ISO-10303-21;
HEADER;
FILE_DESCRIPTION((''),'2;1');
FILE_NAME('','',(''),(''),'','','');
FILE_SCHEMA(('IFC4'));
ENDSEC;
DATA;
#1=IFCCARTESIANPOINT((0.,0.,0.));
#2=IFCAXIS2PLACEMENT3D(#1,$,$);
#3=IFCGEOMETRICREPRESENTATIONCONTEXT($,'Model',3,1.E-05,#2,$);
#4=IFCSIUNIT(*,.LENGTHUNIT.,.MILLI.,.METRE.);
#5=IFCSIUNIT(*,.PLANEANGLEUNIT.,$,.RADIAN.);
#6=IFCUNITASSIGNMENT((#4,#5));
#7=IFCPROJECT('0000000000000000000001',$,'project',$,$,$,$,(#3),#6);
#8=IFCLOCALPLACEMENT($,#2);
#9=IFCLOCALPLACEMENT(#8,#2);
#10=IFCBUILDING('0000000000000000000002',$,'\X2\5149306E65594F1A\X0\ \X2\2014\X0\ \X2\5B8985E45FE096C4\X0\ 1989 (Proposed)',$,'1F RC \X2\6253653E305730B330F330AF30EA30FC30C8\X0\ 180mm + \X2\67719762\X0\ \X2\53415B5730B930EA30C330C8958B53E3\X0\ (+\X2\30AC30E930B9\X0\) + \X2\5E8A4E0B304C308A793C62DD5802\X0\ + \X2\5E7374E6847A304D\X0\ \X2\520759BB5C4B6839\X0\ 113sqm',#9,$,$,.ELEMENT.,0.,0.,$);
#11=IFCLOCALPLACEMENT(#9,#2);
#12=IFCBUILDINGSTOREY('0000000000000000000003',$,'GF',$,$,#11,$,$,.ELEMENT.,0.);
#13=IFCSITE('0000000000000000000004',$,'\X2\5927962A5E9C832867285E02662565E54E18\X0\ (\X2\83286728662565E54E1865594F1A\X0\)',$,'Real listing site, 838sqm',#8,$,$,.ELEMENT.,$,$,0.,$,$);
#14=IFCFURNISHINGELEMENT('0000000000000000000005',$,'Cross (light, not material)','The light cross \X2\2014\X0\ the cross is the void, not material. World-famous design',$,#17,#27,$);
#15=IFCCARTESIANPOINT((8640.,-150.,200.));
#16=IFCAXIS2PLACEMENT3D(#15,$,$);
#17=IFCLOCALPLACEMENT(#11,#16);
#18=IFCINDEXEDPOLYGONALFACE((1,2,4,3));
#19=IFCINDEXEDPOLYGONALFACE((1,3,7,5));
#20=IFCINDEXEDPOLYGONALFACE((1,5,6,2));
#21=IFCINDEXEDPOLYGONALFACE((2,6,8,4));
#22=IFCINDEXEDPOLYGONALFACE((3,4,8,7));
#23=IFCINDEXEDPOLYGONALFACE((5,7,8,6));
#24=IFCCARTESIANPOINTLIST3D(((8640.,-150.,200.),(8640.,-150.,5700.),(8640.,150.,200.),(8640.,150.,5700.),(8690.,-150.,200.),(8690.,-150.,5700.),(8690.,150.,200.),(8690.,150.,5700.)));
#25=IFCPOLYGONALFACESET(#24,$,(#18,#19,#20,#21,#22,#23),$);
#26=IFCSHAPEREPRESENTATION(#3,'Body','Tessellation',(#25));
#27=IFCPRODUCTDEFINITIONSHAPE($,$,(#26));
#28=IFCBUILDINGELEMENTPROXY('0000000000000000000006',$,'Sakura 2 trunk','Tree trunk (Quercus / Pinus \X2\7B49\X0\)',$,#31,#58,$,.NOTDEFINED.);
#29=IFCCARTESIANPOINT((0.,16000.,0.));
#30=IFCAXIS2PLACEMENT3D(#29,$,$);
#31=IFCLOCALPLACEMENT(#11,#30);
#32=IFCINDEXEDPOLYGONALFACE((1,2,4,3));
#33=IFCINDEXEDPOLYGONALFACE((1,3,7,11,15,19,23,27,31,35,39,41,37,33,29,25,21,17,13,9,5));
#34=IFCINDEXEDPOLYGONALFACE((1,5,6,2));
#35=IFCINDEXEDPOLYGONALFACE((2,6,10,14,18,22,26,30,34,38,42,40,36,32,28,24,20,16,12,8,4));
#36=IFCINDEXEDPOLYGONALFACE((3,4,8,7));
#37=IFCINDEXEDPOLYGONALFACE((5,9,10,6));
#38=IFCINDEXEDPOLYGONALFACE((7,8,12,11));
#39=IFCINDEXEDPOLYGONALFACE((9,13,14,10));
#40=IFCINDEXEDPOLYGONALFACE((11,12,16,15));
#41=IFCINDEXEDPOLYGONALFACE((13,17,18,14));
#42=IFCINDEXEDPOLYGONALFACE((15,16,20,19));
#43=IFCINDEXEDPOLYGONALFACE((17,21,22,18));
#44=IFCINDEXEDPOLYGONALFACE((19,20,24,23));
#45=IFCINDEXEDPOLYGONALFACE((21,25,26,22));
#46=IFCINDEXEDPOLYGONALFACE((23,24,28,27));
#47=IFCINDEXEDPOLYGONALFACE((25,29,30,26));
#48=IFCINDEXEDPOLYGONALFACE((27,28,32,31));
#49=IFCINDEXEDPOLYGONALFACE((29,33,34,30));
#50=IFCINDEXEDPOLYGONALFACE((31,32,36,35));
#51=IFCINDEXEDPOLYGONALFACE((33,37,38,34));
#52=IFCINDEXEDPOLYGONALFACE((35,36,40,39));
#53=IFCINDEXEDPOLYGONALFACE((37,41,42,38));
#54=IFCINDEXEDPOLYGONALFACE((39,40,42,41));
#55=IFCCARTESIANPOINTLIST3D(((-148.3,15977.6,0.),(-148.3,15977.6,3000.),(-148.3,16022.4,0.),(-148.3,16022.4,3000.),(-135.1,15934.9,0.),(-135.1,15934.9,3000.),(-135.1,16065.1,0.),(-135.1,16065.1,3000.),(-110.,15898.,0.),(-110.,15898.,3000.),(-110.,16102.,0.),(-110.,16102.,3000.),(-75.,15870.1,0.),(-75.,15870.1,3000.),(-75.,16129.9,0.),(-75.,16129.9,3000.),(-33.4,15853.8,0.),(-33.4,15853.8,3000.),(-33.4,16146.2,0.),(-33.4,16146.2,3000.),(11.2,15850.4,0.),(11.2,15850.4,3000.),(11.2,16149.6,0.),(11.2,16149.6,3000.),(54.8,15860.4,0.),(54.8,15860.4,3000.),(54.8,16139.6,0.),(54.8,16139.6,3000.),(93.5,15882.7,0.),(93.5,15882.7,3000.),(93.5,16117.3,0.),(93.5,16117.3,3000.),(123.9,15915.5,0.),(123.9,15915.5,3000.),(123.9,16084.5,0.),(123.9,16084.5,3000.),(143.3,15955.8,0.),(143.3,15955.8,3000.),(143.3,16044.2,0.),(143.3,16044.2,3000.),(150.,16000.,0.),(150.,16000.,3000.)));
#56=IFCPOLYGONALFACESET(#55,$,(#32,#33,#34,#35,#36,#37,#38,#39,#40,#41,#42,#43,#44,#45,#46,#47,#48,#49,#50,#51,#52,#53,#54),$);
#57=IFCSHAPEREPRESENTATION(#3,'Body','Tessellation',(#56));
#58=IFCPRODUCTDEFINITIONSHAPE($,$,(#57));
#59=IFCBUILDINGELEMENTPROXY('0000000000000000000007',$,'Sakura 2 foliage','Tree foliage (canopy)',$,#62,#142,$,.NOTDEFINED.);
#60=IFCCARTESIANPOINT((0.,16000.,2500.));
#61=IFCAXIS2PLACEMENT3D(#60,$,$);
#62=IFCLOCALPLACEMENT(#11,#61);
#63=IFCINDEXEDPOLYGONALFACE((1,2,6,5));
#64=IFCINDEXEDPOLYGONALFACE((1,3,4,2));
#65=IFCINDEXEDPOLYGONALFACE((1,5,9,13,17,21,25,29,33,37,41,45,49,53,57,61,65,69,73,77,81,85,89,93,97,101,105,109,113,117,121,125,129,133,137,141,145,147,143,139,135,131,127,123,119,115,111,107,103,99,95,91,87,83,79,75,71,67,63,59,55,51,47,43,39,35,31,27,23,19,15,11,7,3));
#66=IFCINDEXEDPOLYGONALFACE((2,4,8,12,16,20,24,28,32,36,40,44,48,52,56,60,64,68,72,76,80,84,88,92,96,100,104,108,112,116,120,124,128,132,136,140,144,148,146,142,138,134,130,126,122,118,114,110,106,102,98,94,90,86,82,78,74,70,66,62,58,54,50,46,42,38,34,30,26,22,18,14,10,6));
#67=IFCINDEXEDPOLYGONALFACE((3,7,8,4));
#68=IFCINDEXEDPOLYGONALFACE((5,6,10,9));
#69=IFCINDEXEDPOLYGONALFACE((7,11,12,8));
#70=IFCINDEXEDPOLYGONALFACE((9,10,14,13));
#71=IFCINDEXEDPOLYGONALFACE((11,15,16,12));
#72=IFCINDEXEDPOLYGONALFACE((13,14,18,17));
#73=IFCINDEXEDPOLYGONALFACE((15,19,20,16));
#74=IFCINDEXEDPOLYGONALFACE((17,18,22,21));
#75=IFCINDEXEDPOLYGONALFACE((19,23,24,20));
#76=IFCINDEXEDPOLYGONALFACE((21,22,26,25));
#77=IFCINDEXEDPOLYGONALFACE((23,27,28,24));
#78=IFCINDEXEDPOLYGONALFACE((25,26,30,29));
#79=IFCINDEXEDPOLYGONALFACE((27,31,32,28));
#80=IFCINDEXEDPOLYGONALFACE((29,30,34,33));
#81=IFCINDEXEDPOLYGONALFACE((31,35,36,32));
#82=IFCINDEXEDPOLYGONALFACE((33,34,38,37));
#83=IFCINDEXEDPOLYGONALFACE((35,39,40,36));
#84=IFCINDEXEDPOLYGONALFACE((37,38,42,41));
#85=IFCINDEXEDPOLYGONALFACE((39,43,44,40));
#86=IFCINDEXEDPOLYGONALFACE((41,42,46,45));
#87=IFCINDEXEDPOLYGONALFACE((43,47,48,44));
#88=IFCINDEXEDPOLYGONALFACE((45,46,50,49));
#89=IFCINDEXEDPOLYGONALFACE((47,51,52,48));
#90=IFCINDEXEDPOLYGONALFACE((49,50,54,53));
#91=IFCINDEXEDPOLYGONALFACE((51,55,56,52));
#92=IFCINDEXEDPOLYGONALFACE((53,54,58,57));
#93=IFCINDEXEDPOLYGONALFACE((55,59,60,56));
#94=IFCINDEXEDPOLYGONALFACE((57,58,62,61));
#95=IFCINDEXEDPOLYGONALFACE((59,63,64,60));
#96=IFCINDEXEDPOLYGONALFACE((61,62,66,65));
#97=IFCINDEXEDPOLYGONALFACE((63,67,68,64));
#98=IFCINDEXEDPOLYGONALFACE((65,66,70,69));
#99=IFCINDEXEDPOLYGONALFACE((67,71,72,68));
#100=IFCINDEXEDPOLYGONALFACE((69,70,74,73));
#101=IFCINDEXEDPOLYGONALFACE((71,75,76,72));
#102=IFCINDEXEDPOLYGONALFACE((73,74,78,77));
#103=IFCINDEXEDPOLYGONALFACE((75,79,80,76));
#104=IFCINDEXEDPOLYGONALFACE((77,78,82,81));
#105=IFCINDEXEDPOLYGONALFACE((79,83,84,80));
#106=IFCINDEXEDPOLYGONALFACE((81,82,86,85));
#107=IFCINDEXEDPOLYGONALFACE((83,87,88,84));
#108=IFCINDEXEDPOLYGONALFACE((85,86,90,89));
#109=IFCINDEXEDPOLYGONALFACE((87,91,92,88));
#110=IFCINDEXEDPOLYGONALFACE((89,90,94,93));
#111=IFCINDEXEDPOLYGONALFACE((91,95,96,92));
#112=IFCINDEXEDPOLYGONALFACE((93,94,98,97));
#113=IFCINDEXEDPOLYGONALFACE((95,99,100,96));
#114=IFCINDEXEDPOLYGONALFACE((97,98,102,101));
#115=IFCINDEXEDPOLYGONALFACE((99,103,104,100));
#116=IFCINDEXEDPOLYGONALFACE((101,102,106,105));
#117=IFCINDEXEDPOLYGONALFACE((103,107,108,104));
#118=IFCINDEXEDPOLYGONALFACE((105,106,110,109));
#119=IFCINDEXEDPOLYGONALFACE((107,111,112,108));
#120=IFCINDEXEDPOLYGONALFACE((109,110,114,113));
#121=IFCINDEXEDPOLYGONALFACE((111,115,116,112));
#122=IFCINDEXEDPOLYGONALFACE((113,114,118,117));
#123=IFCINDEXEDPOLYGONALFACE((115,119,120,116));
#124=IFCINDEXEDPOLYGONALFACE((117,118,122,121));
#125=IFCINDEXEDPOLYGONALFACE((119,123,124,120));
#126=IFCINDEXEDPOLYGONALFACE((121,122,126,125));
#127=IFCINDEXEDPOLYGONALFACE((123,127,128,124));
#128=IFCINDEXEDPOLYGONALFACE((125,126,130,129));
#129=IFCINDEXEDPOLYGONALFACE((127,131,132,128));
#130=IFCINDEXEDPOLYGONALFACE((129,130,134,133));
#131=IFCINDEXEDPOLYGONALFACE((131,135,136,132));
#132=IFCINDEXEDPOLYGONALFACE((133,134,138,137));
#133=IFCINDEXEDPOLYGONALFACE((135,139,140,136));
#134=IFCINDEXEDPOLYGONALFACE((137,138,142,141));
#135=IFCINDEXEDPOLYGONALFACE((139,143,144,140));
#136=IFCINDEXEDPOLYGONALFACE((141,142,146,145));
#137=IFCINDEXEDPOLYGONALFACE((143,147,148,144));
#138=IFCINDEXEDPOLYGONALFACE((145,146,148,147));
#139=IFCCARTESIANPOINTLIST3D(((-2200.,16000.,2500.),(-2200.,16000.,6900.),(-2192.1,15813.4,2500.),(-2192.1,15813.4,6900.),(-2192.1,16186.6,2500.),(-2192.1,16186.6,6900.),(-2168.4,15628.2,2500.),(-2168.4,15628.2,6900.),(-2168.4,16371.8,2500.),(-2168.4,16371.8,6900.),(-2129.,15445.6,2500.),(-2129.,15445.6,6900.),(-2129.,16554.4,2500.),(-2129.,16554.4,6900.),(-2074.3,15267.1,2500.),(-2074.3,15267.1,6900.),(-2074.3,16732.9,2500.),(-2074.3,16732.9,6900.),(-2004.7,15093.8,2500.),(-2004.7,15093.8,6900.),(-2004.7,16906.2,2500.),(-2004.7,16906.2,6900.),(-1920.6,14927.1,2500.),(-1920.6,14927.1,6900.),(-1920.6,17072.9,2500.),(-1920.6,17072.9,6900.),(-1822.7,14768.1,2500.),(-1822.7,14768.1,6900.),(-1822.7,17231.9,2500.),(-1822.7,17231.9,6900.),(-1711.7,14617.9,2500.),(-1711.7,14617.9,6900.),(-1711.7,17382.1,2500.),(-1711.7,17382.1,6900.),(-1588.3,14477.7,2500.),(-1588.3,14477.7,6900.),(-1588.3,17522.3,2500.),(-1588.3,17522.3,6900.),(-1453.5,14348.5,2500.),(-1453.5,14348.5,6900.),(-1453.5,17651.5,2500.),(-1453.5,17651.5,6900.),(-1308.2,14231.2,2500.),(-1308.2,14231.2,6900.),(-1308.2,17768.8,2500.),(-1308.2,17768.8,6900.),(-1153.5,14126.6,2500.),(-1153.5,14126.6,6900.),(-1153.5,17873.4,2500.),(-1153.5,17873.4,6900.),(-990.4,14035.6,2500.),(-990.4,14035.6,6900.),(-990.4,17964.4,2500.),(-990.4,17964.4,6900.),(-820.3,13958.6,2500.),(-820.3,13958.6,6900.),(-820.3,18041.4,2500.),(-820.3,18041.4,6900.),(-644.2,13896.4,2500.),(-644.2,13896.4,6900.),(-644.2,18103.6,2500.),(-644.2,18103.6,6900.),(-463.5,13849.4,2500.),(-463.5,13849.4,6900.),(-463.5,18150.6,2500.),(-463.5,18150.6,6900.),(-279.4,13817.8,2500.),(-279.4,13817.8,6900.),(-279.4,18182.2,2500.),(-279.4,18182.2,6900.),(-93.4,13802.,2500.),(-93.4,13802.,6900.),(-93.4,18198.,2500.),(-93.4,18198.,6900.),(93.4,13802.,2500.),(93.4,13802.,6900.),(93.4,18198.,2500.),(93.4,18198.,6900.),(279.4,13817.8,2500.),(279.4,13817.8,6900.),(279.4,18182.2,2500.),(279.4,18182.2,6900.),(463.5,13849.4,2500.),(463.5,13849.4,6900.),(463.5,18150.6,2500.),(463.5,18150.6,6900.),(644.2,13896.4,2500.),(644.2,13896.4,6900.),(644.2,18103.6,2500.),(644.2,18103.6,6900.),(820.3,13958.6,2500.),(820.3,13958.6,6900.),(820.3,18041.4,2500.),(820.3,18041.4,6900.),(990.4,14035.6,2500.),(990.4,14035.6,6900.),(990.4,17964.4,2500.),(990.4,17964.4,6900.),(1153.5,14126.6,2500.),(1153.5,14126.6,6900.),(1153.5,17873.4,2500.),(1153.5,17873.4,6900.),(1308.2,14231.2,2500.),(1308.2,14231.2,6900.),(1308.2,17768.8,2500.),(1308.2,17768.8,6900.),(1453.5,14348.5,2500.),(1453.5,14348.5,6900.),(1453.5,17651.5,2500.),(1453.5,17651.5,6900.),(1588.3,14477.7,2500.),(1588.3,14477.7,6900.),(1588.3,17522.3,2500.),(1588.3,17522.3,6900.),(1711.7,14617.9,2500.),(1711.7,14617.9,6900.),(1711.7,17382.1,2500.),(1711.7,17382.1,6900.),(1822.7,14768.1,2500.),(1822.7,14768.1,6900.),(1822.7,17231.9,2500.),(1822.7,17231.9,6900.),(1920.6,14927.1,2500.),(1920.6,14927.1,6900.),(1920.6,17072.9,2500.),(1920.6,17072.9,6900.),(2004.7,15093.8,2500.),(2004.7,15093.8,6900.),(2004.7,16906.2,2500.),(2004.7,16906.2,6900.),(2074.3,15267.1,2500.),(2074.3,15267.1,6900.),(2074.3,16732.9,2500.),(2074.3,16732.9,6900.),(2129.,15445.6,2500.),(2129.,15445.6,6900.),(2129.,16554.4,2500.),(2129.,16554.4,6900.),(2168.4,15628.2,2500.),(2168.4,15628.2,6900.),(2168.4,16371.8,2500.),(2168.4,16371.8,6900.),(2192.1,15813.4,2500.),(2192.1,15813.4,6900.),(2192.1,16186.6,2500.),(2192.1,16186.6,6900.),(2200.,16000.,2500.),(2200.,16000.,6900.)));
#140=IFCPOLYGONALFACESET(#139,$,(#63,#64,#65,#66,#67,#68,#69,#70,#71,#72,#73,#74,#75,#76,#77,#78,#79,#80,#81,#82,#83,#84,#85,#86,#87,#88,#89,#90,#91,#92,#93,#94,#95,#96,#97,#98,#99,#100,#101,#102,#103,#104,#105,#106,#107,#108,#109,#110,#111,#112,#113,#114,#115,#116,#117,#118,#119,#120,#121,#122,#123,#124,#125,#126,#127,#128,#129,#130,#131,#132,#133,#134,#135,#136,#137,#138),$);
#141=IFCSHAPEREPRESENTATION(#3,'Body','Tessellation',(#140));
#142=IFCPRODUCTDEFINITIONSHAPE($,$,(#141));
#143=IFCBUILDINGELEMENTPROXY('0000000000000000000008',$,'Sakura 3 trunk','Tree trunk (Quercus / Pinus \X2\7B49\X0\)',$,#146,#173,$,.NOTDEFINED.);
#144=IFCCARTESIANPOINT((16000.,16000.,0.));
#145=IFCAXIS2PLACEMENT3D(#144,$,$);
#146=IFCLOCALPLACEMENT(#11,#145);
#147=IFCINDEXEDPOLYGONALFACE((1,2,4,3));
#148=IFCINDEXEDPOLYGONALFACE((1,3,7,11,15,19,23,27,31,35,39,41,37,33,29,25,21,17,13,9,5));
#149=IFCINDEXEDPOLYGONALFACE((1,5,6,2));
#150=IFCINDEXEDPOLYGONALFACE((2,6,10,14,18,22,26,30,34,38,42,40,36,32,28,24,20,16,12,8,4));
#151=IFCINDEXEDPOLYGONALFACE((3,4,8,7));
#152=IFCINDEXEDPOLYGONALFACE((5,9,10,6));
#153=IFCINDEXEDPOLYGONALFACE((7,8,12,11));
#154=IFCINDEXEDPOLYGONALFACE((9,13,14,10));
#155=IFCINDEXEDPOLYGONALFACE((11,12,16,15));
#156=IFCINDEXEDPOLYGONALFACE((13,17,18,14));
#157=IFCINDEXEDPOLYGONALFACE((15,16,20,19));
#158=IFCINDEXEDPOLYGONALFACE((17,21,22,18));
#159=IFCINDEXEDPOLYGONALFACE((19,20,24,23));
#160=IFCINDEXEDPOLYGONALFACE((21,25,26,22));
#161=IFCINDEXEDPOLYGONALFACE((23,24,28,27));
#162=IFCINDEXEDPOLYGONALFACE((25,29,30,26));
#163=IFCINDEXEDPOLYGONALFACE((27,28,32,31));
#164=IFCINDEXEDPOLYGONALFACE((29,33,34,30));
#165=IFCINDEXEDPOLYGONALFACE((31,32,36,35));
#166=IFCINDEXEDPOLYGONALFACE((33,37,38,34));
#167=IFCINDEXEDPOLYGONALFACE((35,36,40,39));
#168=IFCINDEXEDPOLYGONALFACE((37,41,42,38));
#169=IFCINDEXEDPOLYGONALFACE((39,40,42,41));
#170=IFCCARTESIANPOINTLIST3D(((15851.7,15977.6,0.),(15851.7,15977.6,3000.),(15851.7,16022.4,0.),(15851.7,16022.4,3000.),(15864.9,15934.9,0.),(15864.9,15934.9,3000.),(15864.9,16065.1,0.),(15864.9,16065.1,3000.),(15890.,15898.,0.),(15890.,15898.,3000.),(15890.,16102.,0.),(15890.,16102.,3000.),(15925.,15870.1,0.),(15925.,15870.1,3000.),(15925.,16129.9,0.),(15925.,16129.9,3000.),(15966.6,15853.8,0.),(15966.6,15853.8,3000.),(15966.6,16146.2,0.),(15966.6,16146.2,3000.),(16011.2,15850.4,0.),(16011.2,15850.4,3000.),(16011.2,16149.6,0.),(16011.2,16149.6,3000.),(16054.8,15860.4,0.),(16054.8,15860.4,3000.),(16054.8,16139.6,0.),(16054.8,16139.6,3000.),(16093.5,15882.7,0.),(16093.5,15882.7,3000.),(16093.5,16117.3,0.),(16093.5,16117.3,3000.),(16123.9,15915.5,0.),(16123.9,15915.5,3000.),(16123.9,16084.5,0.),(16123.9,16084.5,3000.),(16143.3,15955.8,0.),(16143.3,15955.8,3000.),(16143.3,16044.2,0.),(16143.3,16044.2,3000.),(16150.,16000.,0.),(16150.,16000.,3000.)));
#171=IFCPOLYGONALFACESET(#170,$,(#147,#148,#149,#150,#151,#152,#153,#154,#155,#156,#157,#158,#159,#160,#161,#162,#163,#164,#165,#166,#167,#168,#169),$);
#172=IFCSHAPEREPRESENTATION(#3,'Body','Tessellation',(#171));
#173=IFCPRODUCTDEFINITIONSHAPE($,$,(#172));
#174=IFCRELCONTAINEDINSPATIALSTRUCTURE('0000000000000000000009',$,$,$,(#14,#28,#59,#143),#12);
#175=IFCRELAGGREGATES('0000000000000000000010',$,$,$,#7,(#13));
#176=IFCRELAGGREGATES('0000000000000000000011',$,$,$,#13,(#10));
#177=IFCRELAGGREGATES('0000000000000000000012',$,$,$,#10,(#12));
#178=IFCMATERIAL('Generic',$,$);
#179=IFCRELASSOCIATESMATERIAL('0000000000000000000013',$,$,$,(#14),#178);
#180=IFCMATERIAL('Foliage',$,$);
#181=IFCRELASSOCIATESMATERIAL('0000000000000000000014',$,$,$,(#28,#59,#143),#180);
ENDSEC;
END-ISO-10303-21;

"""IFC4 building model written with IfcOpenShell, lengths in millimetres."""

from ifc_helpers import new_model, si_unit, frame, frame_2d, origin, origin_2d, place, context, project, spatial, rectangle, circle, extrude, material, element, save


model = new_model("IFC4")

# Units and contexts
model_context = context("Model", 3, precision=1e-05, world=origin())
ifc_project = project(units=[si_unit("LENGTHUNIT", "METRE", prefix="MILLI"), si_unit("PLANEANGLEUNIT", "RADIAN")], contexts=[model_context])

# Site, building, storey
site_placement = place(None, origin())
site = spatial("IfcSite", under=ifc_project, at=site_placement, Name="大阪府茨木市春日丘 (茨木春日丘教会)", ObjectType="Real listing site, 838sqm", CompositionType="ELEMENT", RefElevation=0.0)
building_placement = place(site_placement, origin())
building = spatial("IfcBuilding", under=site, at=building_placement, Name="光の教会 — 安藤忠雄 1989 (Proposed)", ObjectType="1F RC 打放しコンクリート 180mm + 東面 十字スリット開口 (+ガラス) + 床下がり礼拝堂 + 平瓦葺き 切妻屋根 113sqm", CompositionType="ELEMENT", ElevationOfRefHeight=0.0, ElevationOfTerrain=0.0)
storey_placement = place(building_placement, origin())
storey = spatial("IfcBuildingStorey", under=building, at=storey_placement, Name="GF", CompositionType="ELEMENT", Elevation=0.0)

# Shared definitions
ifc_material_1 = material(Name="Generic")

# Furnishing element
furnishing_1_placement = place(storey_placement, frame((8640.0, -150.0, 200.0)))
element("IfcFurnishingElement", 1, at=furnishing_1_placement, inside=storey, material=ifc_material_1, Name="Cross (light, not material)", Description="The light cross — the cross is the void, not material. World-famous design", context=model_context, shape_type="SweptSolid", body=[
    extrude(rectangle(XDim=50.0, YDim=300.0, at=frame_2d((25.0, 150.0))), frame((8640.0, -150.0, 200.0)), (0.0, 0.0, 1.0), 5500.0),
])

# Building element proxies
ifc_material_2 = material(Name="Foliage")
proxy_1_placement = place(storey_placement, frame((0.0, 16000.0, 0.0)))
element("IfcBuildingElementProxy", 2, at=proxy_1_placement, inside=storey, material=ifc_material_2, Name="Sakura 2 trunk", Description="Tree trunk (Quercus / Pinus 等)", PredefinedType="NOTDEFINED", context=model_context, shape_type="SweptSolid", body=[
    extrude(circle(Radius=150.0, at=origin_2d()), frame((0.0, 16000.0, 0.0)), (0.0, 0.0, 1.0), 3000.0),
])
proxy_2_placement = place(storey_placement, frame((0.0, 16000.0, 2500.0)))
element("IfcBuildingElementProxy", 3, at=proxy_2_placement, inside=storey, material=ifc_material_2, Name="Sakura 2 foliage", Description="Tree foliage (canopy)", PredefinedType="NOTDEFINED", context=model_context, shape_type="SweptSolid", body=[
    extrude(circle(Radius=2200.0, at=origin_2d()), frame((0.0, 16000.0, 2500.0)), (0.0, 0.0, 1.0), 4400.0),
])
proxy_3_placement = place(storey_placement, frame((16000.0, 16000.0, 0.0)))
element("IfcBuildingElementProxy", 4, at=proxy_3_placement, inside=storey, material=ifc_material_2, Name="Sakura 3 trunk", Description="Tree trunk (Quercus / Pinus 等)", PredefinedType="NOTDEFINED", context=model_context, shape_type="SweptSolid", body=[
    extrude(circle(Radius=150.0, at=origin_2d()), frame((16000.0, 16000.0, 0.0)), (0.0, 0.0, 1.0), 3000.0),
])

save(model, "model.ifc")
